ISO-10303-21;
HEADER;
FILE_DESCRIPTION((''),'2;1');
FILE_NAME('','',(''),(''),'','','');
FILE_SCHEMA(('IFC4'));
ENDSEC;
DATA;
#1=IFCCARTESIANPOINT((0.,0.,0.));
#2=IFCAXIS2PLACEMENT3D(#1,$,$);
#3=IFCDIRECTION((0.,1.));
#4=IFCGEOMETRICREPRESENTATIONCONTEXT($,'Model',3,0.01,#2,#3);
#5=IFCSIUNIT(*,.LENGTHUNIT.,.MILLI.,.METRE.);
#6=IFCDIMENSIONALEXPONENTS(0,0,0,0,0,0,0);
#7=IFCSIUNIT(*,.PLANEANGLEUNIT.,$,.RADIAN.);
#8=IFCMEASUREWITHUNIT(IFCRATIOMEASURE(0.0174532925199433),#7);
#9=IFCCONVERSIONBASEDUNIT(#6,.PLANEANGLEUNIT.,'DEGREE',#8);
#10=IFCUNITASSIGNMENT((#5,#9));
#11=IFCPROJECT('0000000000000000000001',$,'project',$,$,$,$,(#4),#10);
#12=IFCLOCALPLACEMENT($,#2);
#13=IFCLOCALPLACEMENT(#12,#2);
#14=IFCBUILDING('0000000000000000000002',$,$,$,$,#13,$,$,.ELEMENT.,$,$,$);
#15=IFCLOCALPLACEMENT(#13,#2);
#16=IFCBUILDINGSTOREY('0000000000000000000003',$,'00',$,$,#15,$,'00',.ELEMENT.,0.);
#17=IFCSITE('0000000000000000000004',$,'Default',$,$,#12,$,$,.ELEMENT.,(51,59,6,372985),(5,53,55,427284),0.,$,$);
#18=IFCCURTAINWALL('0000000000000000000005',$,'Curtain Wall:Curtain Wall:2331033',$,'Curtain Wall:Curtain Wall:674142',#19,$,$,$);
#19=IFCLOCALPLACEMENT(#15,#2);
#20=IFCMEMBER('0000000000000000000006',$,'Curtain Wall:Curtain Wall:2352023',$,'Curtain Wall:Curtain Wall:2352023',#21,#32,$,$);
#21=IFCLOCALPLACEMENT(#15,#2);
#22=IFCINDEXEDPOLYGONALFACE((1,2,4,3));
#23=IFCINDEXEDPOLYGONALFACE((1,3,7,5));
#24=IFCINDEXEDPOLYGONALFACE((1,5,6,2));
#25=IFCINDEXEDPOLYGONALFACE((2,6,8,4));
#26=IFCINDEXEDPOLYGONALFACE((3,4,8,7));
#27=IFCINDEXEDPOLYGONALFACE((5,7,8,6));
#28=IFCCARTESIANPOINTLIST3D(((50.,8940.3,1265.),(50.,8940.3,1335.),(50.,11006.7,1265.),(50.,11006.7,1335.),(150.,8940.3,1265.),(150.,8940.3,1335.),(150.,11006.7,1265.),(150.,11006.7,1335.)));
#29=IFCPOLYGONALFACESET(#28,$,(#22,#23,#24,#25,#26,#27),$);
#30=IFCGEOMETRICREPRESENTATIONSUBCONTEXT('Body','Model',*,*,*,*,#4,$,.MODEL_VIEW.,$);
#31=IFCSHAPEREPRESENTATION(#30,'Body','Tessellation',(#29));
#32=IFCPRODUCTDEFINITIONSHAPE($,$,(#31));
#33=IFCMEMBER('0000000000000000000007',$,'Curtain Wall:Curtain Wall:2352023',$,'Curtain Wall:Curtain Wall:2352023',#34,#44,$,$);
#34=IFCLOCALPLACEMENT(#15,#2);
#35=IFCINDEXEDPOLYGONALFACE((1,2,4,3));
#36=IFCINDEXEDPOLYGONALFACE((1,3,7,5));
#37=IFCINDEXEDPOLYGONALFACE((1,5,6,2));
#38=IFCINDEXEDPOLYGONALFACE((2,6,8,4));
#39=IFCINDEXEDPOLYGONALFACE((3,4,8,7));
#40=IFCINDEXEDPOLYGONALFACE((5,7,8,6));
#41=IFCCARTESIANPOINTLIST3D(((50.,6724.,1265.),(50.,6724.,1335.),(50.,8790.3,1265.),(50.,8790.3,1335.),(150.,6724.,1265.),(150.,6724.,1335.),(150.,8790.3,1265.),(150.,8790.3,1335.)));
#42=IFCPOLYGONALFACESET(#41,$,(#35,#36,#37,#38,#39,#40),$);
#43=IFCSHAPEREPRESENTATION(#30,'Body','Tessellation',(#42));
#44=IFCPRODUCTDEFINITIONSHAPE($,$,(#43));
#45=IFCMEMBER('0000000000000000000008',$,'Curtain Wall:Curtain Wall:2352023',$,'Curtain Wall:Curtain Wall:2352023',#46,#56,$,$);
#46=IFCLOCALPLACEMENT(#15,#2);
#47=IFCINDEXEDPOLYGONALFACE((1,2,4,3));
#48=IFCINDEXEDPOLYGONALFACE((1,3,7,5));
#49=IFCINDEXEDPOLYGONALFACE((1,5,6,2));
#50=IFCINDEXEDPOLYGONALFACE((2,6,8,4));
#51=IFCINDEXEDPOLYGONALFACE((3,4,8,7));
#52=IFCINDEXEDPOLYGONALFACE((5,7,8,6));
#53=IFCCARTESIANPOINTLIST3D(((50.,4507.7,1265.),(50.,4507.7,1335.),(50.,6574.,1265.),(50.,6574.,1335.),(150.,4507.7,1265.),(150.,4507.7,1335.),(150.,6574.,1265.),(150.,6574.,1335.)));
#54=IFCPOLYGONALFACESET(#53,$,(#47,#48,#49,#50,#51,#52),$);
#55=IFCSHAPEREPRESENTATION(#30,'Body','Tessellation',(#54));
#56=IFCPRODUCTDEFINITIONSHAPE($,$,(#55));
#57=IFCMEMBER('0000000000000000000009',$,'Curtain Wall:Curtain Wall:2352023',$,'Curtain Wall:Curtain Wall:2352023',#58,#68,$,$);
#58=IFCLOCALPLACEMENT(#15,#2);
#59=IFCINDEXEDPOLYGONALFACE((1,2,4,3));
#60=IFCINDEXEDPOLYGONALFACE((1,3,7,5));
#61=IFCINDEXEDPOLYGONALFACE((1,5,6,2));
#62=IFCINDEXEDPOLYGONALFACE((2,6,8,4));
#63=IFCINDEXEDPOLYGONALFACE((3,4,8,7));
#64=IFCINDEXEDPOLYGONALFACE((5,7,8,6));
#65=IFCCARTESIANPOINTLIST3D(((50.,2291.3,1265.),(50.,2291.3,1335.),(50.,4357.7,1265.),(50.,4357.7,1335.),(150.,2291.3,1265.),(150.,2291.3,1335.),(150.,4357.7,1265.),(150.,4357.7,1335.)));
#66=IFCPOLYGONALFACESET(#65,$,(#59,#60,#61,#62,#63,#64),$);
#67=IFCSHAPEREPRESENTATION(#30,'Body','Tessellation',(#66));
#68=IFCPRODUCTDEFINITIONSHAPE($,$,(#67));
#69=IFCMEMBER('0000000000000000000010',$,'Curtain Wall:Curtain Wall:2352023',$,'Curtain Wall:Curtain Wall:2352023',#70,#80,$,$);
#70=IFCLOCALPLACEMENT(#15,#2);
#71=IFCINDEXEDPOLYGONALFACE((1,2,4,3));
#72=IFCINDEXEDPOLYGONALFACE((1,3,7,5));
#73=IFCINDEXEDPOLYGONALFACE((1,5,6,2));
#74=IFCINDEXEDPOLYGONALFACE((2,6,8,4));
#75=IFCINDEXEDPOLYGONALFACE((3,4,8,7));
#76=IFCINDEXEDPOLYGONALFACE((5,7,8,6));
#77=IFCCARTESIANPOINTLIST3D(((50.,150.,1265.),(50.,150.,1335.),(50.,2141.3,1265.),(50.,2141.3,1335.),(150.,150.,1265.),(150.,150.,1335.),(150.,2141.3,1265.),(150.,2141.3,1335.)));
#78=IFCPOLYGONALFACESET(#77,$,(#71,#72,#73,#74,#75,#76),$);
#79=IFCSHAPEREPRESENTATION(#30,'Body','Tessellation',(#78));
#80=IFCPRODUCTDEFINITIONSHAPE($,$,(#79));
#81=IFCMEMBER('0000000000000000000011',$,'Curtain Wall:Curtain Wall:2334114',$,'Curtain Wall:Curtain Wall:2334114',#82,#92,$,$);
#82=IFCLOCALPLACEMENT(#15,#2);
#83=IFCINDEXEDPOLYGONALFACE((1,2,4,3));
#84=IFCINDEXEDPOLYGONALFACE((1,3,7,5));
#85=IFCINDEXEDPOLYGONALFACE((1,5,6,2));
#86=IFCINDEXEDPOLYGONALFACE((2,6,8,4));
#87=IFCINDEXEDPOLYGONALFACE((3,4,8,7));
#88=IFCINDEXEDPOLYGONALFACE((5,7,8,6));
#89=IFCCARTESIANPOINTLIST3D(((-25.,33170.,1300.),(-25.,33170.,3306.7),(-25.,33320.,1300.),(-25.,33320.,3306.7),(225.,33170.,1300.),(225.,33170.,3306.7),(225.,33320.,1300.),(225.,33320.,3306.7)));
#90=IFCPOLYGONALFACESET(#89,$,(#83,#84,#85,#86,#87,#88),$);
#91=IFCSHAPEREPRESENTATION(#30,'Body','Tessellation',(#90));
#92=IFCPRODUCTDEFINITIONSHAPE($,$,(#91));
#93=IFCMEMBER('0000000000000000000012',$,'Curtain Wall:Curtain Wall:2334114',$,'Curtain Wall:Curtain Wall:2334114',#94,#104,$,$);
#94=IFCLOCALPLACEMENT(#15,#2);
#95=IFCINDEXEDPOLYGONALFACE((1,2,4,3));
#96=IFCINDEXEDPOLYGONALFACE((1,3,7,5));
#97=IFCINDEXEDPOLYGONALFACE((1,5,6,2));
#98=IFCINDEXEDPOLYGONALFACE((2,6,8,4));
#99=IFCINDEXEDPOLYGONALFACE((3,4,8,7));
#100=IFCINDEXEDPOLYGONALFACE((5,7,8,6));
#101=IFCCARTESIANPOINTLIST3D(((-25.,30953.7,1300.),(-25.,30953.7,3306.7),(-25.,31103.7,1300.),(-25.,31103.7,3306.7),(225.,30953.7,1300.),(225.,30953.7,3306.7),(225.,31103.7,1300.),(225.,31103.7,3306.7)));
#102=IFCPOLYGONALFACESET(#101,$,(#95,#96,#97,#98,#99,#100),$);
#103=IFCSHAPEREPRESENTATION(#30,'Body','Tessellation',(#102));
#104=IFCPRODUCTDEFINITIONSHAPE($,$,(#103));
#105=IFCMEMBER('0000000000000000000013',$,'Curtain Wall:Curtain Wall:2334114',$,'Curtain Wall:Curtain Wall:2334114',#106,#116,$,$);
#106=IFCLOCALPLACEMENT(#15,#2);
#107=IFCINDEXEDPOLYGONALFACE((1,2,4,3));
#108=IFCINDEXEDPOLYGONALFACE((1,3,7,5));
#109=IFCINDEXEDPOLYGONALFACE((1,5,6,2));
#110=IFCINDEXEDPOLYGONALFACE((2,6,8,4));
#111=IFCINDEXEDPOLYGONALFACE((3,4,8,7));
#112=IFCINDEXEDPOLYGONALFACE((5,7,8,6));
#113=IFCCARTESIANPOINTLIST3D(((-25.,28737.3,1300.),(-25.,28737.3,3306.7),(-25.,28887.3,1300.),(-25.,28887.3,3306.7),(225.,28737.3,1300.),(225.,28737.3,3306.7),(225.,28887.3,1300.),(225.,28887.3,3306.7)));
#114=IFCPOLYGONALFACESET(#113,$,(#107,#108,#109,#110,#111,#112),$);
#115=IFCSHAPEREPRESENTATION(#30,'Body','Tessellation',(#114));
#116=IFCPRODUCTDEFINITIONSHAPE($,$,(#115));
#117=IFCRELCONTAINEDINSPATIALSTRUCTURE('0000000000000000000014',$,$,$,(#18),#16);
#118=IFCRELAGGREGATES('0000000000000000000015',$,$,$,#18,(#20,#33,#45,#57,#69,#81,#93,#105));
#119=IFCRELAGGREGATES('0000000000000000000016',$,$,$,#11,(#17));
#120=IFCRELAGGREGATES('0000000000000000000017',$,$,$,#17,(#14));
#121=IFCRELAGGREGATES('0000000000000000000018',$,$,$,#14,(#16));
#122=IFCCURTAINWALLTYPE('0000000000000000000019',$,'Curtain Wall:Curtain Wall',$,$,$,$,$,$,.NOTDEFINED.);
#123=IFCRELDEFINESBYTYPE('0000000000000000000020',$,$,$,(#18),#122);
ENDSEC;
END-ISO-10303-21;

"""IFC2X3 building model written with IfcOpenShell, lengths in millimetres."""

from ifc_helpers import new_model, entity, si_unit, converted_unit, direction, frame, frame_2d, origin, origin_2d_with_axis, place, context, subcontext, project, spatial, rectangle, extrude, type_object, element, aggregate, save


model = new_model("IFC2X3")

# Units and contexts
model_context = context("Model", 3, precision=0.01, world=origin(), true_north=direction((0.0, 1.0)))
body_context = subcontext(model_context, "Body", "Model", "MODEL_VIEW")
ifc_project = project(units=[si_unit("LENGTHUNIT", "METRE", prefix="MILLI"), converted_unit("PLANEANGLEUNIT", "DEGREE", entity("IfcRatioMeasure", 0.0174532925199433), si_unit("PLANEANGLEUNIT", "RADIAN"), dimensions=[0, 0, 0, 0, 0, 0, 0])], contexts=[model_context])

# Site, building, storey
site_placement = place(None, origin())
site = spatial("IfcSite", under=ifc_project, at=site_placement, Name="Default", CompositionType="ELEMENT", RefLatitude=(51, 59, 6, 372985), RefLongitude=(5, 53, 55, 427284), RefElevation=0.0)
building_placement = place(site_placement, origin())
building = spatial("IfcBuilding", under=site, at=building_placement, CompositionType="ELEMENT")
storey_placement = place(building_placement, origin())
storey = spatial("IfcBuildingStorey", under=building, at=storey_placement, Name="00", LongName="00", CompositionType="ELEMENT", Elevation=0.0)

# Curtain wall, members
curtain_wall_type = type_object("IfcCurtainWallType", Name="Curtain Wall:Curtain Wall", PredefinedType="NOTDEFINED")
curtain_wall_placement = place(storey_placement, origin())
curtain_wall = element("IfcCurtainWall", 1, at=curtain_wall_placement, inside=storey, type_object=curtain_wall_type, Name="Curtain Wall:Curtain Wall:2331033", ObjectType="Curtain Wall:Curtain Wall:674142")
member_1_placement = place(curtain_wall_placement, origin())
member_1 = element("IfcMember", 2, at=member_1_placement, Name="Curtain Wall:Curtain Wall:2352023", ObjectType="Curtain Wall:Curtain Wall:2352023", context=body_context, shape_type="SweptSolid", body=[
    extrude(rectangle(XDim=70.0, YDim=100.0, at=origin_2d_with_axis()), frame((100.0, 8940.3, 1300.0), z_axis=(0.0, 1.0, 0.0), x_axis=(0.0, 0.0, -1.0)), (0.0, 0.0, 1.0), 2066.3),
])
member_2_placement = place(curtain_wall_placement, origin())
member_2 = element("IfcMember", 3, at=member_2_placement, Name="Curtain Wall:Curtain Wall:2352023", ObjectType="Curtain Wall:Curtain Wall:2352023", context=body_context, shape_type="SweptSolid", body=[
    extrude(rectangle(XDim=70.0, YDim=100.0, at=origin_2d_with_axis()), frame((100.0, 6724.0, 1300.0), z_axis=(0.0, 1.0, 0.0), x_axis=(0.0, 0.0, -1.0)), (0.0, 0.0, 1.0), 2066.3),
])
member_3_placement = place(curtain_wall_placement, origin())
member_3 = element("IfcMember", 4, at=member_3_placement, Name="Curtain Wall:Curtain Wall:2352023", ObjectType="Curtain Wall:Curtain Wall:2352023", context=body_context, shape_type="SweptSolid", body=[
    extrude(rectangle(XDim=70.0, YDim=100.0, at=origin_2d_with_axis()), frame((100.0, 4507.7, 1300.0), z_axis=(0.0, 1.0, 0.0), x_axis=(0.0, 0.0, -1.0)), (0.0, 0.0, 1.0), 2066.3),
])
member_4_placement = place(curtain_wall_placement, origin())
member_4 = element("IfcMember", 5, at=member_4_placement, Name="Curtain Wall:Curtain Wall:2352023", ObjectType="Curtain Wall:Curtain Wall:2352023", context=body_context, shape_type="SweptSolid", body=[
    extrude(rectangle(XDim=70.0, YDim=100.0, at=origin_2d_with_axis()), frame((100.0, 2291.3, 1300.0), z_axis=(0.0, 1.0, 0.0), x_axis=(0.0, 0.0, -1.0)), (0.0, 0.0, 1.0), 2066.3),
])
member_5_placement = place(curtain_wall_placement, origin())
member_5 = element("IfcMember", 6, at=member_5_placement, Name="Curtain Wall:Curtain Wall:2352023", ObjectType="Curtain Wall:Curtain Wall:2352023", context=body_context, shape_type="SweptSolid", body=[
    extrude(rectangle(XDim=70.0, YDim=100.0, at=origin_2d_with_axis()), frame((100.0, 150.0, 1300.0), z_axis=(0.0, 1.0, 0.0), x_axis=(0.0, 0.0, -1.0)), (0.0, 0.0, 1.0), 1991.3),
])
member_6_placement = place(curtain_wall_placement, origin())
member_6 = element("IfcMember", 7, at=member_6_placement, Name="Curtain Wall:Curtain Wall:2334114", ObjectType="Curtain Wall:Curtain Wall:2334114", context=body_context, shape_type="SweptSolid", body=[
    extrude(rectangle(XDim=250.0, YDim=150.0, at=origin_2d_with_axis()), frame((100.0, 33245.0, 1300.0), z_axis=(0.0, 0.0, 1.0), x_axis=(-1.0, 0.0, 0.0)), (0.0, 0.0, 1.0), 2006.7),
])
member_7_placement = place(curtain_wall_placement, origin())
member_7 = element("IfcMember", 8, at=member_7_placement, Name="Curtain Wall:Curtain Wall:2334114", ObjectType="Curtain Wall:Curtain Wall:2334114", context=body_context, shape_type="SweptSolid", body=[
    extrude(rectangle(XDim=250.0, YDim=150.0, at=frame_2d((0.0, 0.0), x_axis=(1.0, 0.0))), frame((100.0, 31028.7, 1300.0), z_axis=(0.0, 0.0, 1.0), x_axis=(-1.0, 0.0, 0.0)), (0.0, 0.0, 1.0), 2006.7),
])
member_8_placement = place(curtain_wall_placement, origin())
member_8 = element("IfcMember", 9, at=member_8_placement, Name="Curtain Wall:Curtain Wall:2334114", ObjectType="Curtain Wall:Curtain Wall:2334114", context=body_context, shape_type="SweptSolid", body=[
    extrude(rectangle(XDim=250.0, YDim=150.0, at=frame_2d((0.0, 0.0), x_axis=(1.0, 0.0))), frame((100.0, 28812.3, 1300.0), z_axis=(0.0, 0.0, 1.0), x_axis=(-1.0, 0.0, 0.0)), (0.0, 0.0, 1.0), 2006.7),
])
aggregate(curtain_wall, [member_1, member_2, member_3, member_4, member_5, member_6, member_7, member_8])

save(model, "model.ifc")
